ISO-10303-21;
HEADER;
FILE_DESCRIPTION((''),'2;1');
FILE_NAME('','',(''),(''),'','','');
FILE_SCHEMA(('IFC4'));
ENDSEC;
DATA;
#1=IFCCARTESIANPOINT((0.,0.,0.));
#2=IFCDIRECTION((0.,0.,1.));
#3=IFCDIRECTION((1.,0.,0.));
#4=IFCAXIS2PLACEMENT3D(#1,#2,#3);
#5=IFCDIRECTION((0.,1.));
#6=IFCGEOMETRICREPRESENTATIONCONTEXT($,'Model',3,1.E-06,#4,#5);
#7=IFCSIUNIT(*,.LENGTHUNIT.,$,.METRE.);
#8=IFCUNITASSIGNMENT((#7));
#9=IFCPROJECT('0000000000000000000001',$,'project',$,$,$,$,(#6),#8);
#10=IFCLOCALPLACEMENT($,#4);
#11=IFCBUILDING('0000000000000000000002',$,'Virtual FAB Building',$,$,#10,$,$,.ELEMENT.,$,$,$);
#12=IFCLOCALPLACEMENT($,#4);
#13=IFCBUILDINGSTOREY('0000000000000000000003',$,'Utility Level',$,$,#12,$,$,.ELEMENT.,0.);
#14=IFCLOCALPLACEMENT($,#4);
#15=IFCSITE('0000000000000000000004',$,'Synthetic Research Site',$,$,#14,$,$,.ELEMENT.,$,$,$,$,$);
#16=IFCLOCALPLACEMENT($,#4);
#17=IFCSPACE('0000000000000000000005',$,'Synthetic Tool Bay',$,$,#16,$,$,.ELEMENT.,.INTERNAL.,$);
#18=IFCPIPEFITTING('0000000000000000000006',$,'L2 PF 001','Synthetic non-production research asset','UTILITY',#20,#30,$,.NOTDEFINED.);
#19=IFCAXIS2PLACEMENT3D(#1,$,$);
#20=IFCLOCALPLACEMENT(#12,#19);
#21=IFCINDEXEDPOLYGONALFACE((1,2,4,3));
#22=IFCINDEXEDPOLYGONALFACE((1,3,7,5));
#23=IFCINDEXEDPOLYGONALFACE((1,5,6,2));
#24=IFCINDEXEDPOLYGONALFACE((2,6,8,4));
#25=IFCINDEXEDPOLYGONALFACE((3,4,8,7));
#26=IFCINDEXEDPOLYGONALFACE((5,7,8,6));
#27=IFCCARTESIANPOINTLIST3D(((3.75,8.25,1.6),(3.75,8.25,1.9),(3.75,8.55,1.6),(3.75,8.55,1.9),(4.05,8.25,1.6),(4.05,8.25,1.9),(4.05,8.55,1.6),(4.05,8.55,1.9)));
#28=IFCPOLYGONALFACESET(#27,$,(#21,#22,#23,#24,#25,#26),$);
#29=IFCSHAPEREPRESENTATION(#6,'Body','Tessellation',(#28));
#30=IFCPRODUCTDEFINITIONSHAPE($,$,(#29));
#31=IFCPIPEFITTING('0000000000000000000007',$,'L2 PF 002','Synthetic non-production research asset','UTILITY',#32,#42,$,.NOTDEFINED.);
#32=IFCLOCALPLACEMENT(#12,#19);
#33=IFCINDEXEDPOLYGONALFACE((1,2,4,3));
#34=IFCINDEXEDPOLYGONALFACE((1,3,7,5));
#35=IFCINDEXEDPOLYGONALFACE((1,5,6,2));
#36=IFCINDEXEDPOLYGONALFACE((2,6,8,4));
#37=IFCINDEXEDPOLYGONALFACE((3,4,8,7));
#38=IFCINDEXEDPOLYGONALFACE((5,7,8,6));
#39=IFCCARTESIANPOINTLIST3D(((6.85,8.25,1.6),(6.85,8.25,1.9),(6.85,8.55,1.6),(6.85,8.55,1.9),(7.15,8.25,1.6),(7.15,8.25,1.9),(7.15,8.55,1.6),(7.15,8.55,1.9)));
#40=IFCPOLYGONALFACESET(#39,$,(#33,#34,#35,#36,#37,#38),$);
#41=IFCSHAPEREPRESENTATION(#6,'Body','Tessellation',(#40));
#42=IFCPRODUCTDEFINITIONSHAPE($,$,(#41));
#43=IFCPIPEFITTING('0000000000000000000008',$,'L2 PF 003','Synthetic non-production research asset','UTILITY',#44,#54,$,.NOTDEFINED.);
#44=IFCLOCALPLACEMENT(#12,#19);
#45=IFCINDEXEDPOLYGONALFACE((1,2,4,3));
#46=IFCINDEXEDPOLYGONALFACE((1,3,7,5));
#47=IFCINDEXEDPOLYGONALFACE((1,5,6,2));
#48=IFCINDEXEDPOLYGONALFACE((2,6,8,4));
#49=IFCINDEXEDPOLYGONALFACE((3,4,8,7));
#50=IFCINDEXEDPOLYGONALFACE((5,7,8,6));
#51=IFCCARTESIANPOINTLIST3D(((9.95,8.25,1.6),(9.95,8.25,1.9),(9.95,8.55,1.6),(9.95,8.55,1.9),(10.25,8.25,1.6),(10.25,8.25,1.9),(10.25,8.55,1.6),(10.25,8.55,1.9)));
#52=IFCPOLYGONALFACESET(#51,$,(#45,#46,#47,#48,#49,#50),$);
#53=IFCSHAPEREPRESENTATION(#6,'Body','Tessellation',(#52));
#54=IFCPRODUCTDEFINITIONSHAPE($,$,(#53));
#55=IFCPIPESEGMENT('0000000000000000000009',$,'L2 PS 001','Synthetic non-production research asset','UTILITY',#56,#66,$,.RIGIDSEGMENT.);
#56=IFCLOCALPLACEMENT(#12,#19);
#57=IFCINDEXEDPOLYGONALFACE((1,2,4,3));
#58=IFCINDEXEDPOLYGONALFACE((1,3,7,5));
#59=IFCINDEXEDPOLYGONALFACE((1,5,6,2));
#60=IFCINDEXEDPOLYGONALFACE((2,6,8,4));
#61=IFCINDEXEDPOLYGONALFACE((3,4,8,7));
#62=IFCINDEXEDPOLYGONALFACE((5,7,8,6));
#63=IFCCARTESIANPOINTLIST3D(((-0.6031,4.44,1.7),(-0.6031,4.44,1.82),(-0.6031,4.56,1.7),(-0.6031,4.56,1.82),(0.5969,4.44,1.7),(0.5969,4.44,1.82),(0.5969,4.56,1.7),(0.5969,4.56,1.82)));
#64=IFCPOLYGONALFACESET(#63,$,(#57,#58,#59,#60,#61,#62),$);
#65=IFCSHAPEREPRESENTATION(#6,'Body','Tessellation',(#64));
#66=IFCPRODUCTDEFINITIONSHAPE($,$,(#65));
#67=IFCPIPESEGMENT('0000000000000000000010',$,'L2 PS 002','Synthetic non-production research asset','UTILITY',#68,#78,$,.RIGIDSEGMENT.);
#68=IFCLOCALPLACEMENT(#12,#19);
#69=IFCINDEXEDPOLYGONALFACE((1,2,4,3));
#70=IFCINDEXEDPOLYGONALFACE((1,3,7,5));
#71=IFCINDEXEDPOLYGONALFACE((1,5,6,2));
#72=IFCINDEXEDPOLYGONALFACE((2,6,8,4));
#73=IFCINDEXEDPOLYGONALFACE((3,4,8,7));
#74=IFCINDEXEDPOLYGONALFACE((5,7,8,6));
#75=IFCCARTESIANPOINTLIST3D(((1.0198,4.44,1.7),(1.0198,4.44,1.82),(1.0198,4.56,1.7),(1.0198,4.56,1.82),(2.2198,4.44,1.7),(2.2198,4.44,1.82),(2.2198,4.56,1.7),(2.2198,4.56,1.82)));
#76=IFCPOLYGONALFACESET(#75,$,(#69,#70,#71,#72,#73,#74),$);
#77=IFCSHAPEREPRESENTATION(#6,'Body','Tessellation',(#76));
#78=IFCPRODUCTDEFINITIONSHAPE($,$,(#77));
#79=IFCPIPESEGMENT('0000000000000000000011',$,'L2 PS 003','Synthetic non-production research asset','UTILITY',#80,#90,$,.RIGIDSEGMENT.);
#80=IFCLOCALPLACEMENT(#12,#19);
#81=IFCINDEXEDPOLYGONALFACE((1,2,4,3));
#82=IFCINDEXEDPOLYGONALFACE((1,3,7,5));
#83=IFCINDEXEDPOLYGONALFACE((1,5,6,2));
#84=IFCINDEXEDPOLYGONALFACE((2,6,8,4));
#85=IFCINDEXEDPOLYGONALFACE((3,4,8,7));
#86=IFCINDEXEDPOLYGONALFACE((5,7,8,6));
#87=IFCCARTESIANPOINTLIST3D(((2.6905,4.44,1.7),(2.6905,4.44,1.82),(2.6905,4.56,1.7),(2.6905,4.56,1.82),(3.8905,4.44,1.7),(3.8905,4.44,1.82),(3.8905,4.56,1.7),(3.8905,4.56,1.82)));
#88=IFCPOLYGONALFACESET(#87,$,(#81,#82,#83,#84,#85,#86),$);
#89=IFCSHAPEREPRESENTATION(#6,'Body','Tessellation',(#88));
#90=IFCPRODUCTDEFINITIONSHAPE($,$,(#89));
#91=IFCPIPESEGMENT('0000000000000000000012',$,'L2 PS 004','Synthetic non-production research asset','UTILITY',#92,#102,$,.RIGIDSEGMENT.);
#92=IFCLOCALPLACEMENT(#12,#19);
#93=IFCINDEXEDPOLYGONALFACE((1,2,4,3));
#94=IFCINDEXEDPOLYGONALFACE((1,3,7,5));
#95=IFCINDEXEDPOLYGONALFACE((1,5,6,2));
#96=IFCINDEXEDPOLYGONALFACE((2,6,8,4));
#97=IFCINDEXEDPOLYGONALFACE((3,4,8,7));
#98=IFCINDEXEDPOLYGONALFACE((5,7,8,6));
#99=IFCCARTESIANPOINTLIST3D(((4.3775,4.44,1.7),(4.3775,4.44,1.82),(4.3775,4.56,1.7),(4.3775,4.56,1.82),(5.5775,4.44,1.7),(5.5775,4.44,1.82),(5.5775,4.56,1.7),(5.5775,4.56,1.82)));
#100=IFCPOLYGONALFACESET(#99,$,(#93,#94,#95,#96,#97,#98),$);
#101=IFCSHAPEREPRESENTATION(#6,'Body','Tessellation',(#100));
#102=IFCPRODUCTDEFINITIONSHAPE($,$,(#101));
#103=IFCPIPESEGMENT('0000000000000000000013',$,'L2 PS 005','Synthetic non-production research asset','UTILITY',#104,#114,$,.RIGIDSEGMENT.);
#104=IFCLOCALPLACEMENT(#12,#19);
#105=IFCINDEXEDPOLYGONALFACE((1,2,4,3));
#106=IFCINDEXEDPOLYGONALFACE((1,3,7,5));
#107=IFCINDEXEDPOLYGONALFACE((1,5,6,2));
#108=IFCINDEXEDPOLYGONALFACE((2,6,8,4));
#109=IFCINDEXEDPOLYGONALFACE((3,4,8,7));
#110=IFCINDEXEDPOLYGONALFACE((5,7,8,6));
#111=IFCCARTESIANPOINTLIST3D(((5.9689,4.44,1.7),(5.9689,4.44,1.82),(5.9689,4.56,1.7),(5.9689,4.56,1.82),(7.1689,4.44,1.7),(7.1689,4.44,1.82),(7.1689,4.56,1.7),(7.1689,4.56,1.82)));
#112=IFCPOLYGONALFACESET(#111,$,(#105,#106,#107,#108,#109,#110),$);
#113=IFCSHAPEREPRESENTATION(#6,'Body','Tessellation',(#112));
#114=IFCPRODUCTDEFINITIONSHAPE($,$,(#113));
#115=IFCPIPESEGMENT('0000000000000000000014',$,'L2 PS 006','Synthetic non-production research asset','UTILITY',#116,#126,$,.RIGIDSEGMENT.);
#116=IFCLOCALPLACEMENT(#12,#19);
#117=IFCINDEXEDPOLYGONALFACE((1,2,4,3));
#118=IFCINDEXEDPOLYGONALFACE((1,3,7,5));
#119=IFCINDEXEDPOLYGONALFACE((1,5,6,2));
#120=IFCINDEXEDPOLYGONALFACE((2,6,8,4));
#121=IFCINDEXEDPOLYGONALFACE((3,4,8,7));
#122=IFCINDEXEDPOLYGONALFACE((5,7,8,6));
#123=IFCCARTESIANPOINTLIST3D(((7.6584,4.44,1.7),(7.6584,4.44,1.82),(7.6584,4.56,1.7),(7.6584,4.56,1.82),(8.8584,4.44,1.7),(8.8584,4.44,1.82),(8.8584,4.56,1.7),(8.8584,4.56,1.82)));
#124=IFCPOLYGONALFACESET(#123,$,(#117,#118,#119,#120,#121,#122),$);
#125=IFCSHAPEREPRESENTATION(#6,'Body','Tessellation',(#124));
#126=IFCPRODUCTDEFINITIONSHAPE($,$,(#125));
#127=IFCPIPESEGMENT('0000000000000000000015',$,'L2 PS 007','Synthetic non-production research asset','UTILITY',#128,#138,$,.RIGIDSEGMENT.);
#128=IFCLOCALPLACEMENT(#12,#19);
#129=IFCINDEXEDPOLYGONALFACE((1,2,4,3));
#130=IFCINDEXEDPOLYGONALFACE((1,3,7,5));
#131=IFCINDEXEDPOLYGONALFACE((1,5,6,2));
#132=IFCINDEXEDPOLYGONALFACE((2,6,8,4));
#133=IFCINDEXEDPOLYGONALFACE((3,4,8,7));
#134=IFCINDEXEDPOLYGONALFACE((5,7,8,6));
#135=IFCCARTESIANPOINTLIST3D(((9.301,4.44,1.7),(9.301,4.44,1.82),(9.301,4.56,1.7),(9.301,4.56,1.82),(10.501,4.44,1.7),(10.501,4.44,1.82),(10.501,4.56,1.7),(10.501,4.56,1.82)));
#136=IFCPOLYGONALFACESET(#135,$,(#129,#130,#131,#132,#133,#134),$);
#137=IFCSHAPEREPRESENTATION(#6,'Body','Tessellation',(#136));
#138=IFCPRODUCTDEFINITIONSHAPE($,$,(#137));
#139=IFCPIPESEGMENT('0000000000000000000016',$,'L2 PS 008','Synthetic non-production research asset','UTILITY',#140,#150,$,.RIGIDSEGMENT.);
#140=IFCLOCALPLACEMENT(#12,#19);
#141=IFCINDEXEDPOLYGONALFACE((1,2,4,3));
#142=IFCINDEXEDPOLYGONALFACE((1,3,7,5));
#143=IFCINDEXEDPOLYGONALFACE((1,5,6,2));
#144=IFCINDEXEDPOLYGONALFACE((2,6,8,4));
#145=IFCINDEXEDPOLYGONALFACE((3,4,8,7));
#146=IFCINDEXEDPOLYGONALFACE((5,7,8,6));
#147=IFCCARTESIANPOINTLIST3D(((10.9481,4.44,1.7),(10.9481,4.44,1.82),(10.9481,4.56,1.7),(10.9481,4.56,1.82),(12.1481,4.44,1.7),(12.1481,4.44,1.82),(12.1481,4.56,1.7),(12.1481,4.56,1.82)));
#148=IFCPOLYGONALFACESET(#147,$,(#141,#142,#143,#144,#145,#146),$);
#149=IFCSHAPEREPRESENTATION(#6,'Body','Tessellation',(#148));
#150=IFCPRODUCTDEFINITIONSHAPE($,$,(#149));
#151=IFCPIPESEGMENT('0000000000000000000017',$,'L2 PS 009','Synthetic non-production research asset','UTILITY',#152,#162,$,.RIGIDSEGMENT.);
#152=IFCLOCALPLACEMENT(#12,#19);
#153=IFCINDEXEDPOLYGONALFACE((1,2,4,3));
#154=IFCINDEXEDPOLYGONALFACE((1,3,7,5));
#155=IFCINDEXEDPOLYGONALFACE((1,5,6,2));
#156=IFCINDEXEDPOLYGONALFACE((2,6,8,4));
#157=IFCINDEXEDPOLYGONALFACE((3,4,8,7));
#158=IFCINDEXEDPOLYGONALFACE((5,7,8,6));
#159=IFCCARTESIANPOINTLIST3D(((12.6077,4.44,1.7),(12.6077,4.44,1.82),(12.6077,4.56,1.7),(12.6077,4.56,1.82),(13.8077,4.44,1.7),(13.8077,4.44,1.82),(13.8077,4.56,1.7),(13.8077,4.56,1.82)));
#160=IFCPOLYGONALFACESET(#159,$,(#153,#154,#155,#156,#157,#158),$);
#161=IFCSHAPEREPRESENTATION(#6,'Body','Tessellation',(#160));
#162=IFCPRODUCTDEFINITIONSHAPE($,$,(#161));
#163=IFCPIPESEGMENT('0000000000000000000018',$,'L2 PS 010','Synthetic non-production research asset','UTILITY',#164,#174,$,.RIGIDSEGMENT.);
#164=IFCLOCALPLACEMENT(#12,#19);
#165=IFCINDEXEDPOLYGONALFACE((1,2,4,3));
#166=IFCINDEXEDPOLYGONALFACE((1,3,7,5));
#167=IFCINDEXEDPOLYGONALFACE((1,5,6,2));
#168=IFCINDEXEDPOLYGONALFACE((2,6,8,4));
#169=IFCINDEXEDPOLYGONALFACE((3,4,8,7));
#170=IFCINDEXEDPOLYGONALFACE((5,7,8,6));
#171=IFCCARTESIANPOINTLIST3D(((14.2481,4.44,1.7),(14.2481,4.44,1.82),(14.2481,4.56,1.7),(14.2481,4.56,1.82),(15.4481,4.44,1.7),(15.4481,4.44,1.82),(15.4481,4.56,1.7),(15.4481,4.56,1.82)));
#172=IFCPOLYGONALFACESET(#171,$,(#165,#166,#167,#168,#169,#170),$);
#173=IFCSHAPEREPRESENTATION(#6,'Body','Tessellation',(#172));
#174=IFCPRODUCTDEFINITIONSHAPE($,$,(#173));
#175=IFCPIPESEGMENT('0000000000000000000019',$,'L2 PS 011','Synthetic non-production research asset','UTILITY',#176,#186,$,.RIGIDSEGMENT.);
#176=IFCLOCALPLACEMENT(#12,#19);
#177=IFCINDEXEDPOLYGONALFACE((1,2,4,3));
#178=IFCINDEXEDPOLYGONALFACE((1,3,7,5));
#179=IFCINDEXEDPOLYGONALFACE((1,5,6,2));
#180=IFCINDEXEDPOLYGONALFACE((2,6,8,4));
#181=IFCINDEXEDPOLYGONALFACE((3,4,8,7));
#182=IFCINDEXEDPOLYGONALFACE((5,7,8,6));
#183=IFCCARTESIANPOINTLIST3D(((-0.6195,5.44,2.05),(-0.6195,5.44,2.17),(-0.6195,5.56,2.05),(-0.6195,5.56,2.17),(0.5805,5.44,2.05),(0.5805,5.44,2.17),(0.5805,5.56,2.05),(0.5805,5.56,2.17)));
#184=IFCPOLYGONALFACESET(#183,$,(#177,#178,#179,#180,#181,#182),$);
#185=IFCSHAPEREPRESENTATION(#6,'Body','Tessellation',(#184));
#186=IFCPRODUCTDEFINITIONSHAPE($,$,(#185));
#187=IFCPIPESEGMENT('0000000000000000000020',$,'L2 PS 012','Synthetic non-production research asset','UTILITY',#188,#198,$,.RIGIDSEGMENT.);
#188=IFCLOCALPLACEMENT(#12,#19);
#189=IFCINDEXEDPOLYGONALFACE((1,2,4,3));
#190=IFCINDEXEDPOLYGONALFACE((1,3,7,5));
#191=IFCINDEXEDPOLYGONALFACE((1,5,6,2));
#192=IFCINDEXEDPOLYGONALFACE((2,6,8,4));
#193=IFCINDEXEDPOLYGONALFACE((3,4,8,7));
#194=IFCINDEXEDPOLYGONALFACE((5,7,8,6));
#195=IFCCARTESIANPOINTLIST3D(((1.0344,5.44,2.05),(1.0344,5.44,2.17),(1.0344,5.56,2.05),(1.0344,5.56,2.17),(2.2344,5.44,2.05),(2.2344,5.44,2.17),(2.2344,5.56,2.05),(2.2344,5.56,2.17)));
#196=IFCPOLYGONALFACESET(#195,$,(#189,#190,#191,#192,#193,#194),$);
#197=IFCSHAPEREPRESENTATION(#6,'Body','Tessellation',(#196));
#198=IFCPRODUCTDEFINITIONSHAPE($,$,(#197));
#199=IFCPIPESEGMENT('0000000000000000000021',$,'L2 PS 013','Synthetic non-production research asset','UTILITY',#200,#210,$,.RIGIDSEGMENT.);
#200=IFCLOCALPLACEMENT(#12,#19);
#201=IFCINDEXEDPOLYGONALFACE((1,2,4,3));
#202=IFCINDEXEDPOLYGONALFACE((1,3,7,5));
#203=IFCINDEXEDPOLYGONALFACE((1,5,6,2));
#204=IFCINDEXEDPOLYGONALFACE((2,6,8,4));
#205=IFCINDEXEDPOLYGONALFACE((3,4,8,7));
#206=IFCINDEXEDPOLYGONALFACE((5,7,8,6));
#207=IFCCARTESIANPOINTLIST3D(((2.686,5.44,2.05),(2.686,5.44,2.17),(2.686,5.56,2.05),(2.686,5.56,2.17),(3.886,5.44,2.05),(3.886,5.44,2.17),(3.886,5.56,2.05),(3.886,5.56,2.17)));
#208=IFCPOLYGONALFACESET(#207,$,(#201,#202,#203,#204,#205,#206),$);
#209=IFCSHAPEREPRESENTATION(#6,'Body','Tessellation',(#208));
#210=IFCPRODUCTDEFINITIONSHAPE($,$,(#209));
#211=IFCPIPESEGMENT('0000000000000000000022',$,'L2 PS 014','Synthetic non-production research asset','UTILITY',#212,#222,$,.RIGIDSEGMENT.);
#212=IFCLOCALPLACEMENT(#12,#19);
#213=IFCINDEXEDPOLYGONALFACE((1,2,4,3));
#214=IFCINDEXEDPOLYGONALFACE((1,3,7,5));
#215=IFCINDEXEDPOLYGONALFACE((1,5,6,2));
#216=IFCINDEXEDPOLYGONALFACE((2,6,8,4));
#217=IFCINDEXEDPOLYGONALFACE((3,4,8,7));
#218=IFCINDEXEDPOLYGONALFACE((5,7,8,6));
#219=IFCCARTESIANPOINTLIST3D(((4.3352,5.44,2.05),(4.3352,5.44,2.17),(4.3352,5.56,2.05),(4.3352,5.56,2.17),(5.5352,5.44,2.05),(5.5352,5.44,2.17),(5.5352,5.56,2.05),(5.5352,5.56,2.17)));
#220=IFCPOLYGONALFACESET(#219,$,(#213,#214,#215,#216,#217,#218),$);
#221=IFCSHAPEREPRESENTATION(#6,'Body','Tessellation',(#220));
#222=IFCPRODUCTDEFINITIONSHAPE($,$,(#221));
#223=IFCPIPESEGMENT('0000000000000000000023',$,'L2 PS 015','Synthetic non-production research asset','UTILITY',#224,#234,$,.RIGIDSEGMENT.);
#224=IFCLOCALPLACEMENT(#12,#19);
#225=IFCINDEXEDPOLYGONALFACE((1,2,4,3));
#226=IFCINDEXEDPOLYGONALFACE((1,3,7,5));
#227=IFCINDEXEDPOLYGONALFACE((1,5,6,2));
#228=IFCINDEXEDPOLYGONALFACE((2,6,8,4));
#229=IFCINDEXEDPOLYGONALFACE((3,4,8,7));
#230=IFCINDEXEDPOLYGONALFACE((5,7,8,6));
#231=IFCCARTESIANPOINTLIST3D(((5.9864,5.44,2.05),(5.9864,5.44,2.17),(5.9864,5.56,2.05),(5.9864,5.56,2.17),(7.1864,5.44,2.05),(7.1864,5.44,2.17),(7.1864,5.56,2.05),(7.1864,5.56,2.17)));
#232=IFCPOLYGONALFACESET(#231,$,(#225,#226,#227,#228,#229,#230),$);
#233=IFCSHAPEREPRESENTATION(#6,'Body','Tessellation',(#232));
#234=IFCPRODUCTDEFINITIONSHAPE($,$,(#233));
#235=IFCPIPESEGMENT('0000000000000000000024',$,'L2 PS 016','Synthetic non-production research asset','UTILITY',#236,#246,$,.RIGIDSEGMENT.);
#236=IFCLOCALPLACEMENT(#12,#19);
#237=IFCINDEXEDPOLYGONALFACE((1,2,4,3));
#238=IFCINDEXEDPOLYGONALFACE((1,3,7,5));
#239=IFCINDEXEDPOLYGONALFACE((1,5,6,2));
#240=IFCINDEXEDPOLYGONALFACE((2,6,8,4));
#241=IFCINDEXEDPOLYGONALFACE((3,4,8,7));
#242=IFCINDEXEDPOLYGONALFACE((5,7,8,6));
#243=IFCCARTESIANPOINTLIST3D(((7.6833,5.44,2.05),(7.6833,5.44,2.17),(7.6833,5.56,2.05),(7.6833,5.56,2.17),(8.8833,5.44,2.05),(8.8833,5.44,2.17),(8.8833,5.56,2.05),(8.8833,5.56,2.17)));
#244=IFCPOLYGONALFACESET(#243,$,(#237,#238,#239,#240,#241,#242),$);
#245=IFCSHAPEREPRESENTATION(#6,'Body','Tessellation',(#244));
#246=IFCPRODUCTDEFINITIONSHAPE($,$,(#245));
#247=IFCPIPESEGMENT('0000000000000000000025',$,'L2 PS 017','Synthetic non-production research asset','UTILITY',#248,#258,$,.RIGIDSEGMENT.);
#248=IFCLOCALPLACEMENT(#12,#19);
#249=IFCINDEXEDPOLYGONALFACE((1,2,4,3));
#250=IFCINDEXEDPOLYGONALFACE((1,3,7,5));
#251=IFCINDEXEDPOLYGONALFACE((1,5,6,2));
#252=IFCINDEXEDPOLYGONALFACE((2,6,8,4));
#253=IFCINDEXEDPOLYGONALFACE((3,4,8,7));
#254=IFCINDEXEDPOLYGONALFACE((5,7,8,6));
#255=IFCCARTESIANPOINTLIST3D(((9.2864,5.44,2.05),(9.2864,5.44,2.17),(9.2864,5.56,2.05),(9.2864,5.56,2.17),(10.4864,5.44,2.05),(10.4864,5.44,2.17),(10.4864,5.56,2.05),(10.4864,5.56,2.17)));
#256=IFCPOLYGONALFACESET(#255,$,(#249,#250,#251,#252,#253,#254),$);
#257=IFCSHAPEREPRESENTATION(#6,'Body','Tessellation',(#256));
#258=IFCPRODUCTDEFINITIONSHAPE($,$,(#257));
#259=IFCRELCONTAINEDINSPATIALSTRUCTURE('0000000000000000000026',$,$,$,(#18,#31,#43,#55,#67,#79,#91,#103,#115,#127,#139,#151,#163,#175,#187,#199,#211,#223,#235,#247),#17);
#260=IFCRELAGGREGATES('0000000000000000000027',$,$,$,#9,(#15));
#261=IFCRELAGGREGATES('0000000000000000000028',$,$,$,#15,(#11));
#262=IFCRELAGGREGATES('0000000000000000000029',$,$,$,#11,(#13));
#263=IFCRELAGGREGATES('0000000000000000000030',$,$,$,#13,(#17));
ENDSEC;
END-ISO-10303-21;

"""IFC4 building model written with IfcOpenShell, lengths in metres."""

from ifc_helpers import new_model, si_unit, direction, frame, origin_with_axes, origin_2d_with_axis, place, context, project, spatial, rectangle, extrude, element, save


model = new_model("IFC4")

# Units and contexts
model_context = context("Model", 3, precision=1e-06, world=origin_with_axes(), true_north=direction((0.0, 1.0)))
ifc_project = project(units=[si_unit("LENGTHUNIT", "METRE")], contexts=[model_context])

# Site, building, storey, space
site_placement = place(None, origin_with_axes())
site = spatial("IfcSite", under=ifc_project, at=site_placement, Name="Synthetic Research Site", CompositionType="ELEMENT")
building_placement = place(None, origin_with_axes())
building = spatial("IfcBuilding", under=site, at=building_placement, Name="Virtual FAB Building", CompositionType="ELEMENT")
storey_placement = place(None, origin_with_axes())
storey = spatial("IfcBuildingStorey", under=building, at=storey_placement, Name="Utility Level", CompositionType="ELEMENT", Elevation=0.0)
space_placement = place(None, origin_with_axes())
space = spatial("IfcSpace", under=storey, at=space_placement, Name="Synthetic Tool Bay", CompositionType="ELEMENT", PredefinedType="INTERNAL")

# Pipe fittings
for number, where, z_axis, x_axis, name in (
    (1, (3.9, 8.4, 1.6), (0.0, 0.0, 1.0), (1.0, 0.0, 0.0), "L2 PF 001"),
    (2, (7.0, 8.4, 1.6), (0.0, 0.0, 1.0), (1.0, 0.0, 0.0), "L2 PF 002"),
    (3, (10.1, 8.4, 1.6), (0.0, 0.0, 1.0), (1.0, 0.0, 0.0), "L2 PF 003"),
):
    element("IfcPipeFitting", number, at=place(None, frame(where, z_axis=z_axis, x_axis=x_axis)), inside=space, Name=name, Description="Synthetic non-production research asset", ObjectType="UTILITY", PredefinedType="NOTDEFINED", context=model_context, shape_type="SweptSolid", body=[
        extrude(rectangle(XDim=0.3, YDim=0.3, at=origin_2d_with_axis()), origin_with_axes(), (0.0, 0.0, 1.0), 0.3),
    ])

# Pipe segments
for number, where, z_axis, x_axis, name in (
    (4, (-0.0031, 4.5, 1.7), (0.0, 0.0, 1.0), (1.0, 0.0, 0.0), "L2 PS 001"),
    (5, (1.6198, 4.5, 1.7), (0.0, 0.0, 1.0), (1.0, 0.0, 0.0), "L2 PS 002"),
    (6, (3.2905, 4.5, 1.7), (0.0, 0.0, 1.0), (1.0, 0.0, 0.0), "L2 PS 003"),
    (7, (4.9775, 4.5, 1.7), (0.0, 0.0, 1.0), (1.0, 0.0, 0.0), "L2 PS 004"),
    (8, (6.5689, 4.5, 1.7), (0.0, 0.0, 1.0), (1.0, 0.0, 0.0), "L2 PS 005"),
    (9, (8.2584, 4.5, 1.7), (0.0, 0.0, 1.0), (1.0, 0.0, 0.0), "L2 PS 006"),
    (10, (9.901, 4.5, 1.7), (0.0, 0.0, 1.0), (1.0, 0.0, 0.0), "L2 PS 007"),
    (11, (11.5481, 4.5, 1.7), (0.0, 0.0, 1.0), (1.0, 0.0, 0.0), "L2 PS 008"),
    (12, (13.2077, 4.5, 1.7), (0.0, 0.0, 1.0), (1.0, 0.0, 0.0), "L2 PS 009"),
    (13, (14.8481, 4.5, 1.7), (0.0, 0.0, 1.0), (1.0, 0.0, 0.0), "L2 PS 010"),
    (14, (-0.0195, 5.5, 2.05), (0.0, 0.0, 1.0), (1.0, 0.0, 0.0), "L2 PS 011"),
    (15, (1.6344, 5.5, 2.05), (0.0, 0.0, 1.0), (1.0, 0.0, 0.0), "L2 PS 012"),
    (16, (3.286, 5.5, 2.05), (0.0, 0.0, 1.0), (1.0, 0.0, 0.0), "L2 PS 013"),
    (17, (4.9352, 5.5, 2.05), (0.0, 0.0, 1.0), (1.0, 0.0, 0.0), "L2 PS 014"),
    (18, (6.5864, 5.5, 2.05), (0.0, 0.0, 1.0), (1.0, 0.0, 0.0), "L2 PS 015"),
    (19, (8.2833, 5.5, 2.05), (0.0, 0.0, 1.0), (1.0, 0.0, 0.0), "L2 PS 016"),
    (20, (9.8864, 5.5, 2.05), (0.0, 0.0, 1.0), (1.0, 0.0, 0.0), "L2 PS 017"),
):
    element("IfcPipeSegment", number, at=place(None, frame(where, z_axis=z_axis, x_axis=x_axis)), inside=space, Name=name, Description="Synthetic non-production research asset", ObjectType="UTILITY", PredefinedType="RIGIDSEGMENT", context=model_context, shape_type="SweptSolid", body=[
        extrude(rectangle(XDim=1.2, YDim=0.12, at=origin_2d_with_axis()), origin_with_axes(), (0.0, 0.0, 1.0), 0.12),
    ])

save(model, "model.ifc")
